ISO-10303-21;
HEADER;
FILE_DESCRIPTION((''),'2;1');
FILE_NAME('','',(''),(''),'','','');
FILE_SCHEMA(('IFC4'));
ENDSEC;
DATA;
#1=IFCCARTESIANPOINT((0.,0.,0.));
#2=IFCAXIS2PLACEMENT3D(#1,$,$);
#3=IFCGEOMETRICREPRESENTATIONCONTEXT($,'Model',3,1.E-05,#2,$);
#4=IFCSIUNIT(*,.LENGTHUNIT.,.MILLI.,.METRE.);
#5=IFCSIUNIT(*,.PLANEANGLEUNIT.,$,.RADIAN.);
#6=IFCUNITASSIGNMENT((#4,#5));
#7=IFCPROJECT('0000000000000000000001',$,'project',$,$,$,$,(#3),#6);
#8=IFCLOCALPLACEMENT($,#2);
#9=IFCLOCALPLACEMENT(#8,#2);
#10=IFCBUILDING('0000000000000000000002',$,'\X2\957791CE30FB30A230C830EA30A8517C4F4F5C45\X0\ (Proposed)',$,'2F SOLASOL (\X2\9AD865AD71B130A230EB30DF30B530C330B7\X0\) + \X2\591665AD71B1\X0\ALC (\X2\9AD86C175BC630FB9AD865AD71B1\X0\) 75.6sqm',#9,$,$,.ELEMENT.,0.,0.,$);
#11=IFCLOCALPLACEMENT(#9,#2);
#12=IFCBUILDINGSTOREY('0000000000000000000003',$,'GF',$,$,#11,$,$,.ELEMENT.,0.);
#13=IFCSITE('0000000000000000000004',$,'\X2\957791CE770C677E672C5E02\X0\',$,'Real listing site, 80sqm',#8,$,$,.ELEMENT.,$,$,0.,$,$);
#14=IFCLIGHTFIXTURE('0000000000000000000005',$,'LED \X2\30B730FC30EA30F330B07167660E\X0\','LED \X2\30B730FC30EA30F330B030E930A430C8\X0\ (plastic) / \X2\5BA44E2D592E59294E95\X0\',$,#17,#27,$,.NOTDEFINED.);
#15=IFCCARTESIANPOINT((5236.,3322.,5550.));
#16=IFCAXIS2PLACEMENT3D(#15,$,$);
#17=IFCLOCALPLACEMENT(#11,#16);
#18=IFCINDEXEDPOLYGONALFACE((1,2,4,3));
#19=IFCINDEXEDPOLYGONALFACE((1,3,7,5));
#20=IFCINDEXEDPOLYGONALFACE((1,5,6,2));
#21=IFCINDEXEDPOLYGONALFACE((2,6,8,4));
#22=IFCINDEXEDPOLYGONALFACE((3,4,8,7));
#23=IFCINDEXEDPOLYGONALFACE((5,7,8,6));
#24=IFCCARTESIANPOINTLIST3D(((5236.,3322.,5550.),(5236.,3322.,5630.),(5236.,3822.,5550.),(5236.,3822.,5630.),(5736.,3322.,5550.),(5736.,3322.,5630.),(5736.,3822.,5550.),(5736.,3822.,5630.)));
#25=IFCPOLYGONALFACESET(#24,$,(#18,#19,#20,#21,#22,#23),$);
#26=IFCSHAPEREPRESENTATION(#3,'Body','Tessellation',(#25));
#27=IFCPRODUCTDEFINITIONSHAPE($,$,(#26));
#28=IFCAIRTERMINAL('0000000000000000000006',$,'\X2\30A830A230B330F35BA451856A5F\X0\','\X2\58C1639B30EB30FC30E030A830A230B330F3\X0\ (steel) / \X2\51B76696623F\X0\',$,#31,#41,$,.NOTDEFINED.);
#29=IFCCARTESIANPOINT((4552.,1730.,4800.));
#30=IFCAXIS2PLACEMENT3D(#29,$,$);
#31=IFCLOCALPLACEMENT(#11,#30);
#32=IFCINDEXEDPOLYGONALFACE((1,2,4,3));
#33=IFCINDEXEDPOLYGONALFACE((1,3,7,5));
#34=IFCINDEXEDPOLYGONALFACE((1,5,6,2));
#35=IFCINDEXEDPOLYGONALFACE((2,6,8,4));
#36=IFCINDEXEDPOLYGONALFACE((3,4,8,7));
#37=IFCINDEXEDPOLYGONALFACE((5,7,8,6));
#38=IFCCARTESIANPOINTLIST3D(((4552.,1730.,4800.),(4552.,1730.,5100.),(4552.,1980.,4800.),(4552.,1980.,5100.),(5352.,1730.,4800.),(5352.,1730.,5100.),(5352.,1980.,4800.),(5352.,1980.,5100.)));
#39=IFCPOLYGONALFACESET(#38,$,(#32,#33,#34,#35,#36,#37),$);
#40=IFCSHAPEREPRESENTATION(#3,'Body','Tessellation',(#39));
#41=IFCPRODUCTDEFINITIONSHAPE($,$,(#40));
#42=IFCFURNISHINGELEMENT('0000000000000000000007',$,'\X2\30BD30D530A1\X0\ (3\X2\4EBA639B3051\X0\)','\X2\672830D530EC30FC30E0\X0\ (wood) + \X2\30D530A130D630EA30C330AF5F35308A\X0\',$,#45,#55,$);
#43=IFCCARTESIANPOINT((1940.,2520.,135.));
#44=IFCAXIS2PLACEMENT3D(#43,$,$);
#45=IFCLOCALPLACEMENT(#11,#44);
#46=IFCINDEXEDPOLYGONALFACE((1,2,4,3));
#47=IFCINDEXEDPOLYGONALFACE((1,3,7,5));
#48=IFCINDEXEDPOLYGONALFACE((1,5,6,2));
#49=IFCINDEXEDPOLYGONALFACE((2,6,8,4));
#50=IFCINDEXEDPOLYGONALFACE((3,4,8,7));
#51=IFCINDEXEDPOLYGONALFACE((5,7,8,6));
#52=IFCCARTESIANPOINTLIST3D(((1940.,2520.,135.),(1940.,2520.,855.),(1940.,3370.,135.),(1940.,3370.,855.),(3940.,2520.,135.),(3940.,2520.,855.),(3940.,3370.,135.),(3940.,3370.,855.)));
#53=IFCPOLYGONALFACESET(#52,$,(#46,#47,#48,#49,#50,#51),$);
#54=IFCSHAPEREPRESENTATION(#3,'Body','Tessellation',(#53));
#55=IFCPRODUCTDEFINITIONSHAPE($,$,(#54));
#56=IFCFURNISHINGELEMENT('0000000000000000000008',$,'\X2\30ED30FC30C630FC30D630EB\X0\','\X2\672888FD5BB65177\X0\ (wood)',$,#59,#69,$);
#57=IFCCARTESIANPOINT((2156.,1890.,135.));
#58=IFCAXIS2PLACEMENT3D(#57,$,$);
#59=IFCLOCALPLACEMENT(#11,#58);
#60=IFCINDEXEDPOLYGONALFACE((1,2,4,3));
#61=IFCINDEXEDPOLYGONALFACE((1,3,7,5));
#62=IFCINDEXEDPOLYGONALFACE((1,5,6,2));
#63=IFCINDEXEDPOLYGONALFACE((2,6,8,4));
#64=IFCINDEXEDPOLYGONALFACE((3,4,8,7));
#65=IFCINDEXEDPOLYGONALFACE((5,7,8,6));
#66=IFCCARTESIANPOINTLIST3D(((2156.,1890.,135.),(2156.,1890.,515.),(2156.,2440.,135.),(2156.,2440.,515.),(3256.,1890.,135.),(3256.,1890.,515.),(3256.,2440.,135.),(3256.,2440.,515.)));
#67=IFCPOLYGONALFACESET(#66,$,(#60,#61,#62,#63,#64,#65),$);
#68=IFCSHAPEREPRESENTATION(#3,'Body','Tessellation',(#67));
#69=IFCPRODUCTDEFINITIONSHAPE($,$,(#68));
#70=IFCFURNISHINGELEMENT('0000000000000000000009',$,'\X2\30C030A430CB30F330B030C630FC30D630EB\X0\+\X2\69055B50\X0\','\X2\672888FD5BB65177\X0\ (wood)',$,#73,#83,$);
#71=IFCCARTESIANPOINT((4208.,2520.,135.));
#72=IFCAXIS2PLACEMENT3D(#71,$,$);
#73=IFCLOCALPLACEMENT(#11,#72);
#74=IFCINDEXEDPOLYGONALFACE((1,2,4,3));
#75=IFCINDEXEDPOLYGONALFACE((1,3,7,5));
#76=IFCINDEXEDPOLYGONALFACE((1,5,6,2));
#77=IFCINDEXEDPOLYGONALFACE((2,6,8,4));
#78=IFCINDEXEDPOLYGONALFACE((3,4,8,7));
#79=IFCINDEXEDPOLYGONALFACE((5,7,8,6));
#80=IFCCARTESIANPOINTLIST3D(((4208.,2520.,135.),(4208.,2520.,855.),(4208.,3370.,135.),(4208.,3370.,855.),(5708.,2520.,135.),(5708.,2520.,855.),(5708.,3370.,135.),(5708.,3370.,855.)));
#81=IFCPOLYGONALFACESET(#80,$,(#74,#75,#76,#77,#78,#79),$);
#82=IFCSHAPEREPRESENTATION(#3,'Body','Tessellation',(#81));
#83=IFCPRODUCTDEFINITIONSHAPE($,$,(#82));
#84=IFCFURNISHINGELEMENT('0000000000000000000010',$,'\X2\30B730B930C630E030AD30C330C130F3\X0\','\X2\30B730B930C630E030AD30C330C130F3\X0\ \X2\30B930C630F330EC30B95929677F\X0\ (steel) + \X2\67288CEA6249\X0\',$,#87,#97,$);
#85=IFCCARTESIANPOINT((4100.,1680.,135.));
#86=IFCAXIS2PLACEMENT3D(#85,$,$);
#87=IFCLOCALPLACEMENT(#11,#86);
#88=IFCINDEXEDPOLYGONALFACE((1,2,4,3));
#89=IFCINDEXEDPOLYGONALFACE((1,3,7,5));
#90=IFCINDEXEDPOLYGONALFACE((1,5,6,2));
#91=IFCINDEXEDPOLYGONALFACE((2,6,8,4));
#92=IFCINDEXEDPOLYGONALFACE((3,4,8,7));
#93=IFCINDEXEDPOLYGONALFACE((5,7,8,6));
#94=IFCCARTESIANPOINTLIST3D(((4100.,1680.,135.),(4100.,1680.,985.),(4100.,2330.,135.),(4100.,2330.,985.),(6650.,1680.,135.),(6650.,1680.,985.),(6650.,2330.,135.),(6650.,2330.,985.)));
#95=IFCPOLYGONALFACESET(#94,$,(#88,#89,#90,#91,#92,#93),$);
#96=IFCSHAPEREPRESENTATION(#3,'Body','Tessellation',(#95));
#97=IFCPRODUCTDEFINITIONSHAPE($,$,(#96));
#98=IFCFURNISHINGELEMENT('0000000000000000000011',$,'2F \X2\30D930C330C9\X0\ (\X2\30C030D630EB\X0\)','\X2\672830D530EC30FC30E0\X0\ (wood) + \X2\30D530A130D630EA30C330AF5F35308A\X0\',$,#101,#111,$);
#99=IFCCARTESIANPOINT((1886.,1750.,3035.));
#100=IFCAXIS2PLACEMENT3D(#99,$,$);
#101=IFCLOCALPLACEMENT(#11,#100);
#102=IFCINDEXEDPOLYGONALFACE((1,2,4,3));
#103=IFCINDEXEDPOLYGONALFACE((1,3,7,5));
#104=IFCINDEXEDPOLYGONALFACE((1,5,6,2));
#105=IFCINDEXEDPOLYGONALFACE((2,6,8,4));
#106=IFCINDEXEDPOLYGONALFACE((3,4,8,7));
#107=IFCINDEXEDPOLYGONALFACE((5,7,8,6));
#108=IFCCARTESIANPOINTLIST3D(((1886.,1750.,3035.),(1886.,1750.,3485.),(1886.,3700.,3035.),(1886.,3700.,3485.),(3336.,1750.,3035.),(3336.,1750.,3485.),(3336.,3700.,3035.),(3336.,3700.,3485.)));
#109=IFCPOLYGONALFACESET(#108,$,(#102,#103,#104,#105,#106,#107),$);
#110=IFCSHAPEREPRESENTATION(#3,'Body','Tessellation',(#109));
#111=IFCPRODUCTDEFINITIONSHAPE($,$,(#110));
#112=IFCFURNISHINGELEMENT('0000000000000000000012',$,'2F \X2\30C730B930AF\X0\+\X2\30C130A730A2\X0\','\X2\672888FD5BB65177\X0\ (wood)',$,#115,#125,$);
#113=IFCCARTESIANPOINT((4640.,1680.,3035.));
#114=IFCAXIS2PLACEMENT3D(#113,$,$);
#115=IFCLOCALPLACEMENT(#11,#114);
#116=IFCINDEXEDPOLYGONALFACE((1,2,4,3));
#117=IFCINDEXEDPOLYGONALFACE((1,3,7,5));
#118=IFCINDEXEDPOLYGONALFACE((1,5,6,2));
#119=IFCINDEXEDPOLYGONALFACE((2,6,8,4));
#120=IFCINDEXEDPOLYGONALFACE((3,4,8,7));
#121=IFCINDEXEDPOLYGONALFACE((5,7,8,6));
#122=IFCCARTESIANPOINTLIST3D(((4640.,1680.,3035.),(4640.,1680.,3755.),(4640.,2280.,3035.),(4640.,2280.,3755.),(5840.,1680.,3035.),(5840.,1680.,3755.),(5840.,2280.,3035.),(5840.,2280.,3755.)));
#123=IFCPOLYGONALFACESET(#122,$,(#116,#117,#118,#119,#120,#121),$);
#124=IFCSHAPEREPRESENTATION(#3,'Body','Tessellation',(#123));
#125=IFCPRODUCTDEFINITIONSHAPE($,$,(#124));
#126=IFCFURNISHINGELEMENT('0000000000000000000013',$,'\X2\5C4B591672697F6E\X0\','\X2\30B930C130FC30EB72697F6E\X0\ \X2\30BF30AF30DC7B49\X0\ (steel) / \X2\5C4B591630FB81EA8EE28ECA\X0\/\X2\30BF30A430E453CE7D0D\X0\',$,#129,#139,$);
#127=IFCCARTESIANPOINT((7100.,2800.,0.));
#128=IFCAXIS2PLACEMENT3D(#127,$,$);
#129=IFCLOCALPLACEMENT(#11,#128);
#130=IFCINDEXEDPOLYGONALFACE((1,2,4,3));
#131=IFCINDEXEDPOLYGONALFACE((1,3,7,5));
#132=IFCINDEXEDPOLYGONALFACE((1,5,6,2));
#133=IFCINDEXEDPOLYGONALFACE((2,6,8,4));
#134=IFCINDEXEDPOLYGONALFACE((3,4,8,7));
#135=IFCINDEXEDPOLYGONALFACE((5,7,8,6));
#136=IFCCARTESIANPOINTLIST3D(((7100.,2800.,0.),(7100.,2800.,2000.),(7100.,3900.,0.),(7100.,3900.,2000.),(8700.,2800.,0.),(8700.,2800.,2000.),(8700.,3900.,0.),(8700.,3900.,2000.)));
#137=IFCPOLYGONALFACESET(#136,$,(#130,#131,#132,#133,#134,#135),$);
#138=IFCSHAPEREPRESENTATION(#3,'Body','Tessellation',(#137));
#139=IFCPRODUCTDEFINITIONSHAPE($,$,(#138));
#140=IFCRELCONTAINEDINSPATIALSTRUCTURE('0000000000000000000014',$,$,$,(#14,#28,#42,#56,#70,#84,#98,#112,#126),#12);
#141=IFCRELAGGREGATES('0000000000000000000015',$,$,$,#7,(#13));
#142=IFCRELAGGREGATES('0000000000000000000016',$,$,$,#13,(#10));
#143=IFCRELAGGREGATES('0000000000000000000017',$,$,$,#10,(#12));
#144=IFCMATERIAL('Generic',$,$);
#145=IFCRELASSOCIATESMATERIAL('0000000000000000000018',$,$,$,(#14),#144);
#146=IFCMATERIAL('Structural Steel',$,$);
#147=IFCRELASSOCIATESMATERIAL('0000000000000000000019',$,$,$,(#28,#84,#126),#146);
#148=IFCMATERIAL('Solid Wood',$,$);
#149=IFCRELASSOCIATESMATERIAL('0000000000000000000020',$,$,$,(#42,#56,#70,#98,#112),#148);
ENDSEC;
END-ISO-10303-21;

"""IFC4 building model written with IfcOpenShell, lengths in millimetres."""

from ifc_helpers import new_model, si_unit, frame, frame_2d, origin, place, context, project, spatial, rectangle, extrude, material, element, save


model = new_model("IFC4")

# Units and contexts
model_context = context("Model", 3, precision=1e-05, world=origin())
ifc_project = project(units=[si_unit("LENGTHUNIT", "METRE", prefix="MILLI"), si_unit("PLANEANGLEUNIT", "RADIAN")], contexts=[model_context])

# Site, building, storey
site_placement = place(None, origin())
site = spatial("IfcSite", under=ifc_project, at=site_placement, Name="長野県松本市", ObjectType="Real listing site, 80sqm", CompositionType="ELEMENT", RefElevation=0.0)
building_placement = place(site_placement, origin())
building = spatial("IfcBuilding", under=site, at=building_placement, Name="長野・アトリエ兼住居 (Proposed)", ObjectType="2F SOLASOL (高断熱アルミサッシ) + 外断熱ALC (高気密・高断熱) 75.6sqm", CompositionType="ELEMENT", ElevationOfRefHeight=0.0, ElevationOfTerrain=0.0)
storey_placement = place(building_placement, origin())
storey = spatial("IfcBuildingStorey", under=building, at=storey_placement, Name="GF", CompositionType="ELEMENT", Elevation=0.0)

# Shared definitions
ifc_material_1 = material(Name="Solid Wood")

# Shared definitions
ifc_material_2 = material(Name="Generic")

# Shared definitions
ifc_material_3 = material(Name="Structural Steel")

# Light fixture
light_fixture_placement = place(storey_placement, frame((5236.0, 3322.0, 5550.0)))
element("IfcLightFixture", 1, at=light_fixture_placement, inside=storey, material=ifc_material_2, Name="LED シーリング照明", Description="LED シーリングライト (plastic) / 室中央天井", PredefinedType="NOTDEFINED", context=model_context, shape_type="SweptSolid", body=[
    extrude(rectangle(XDim=500.0, YDim=500.0, at=frame_2d((250.0, 250.0))), frame((5236.0, 3322.0, 5550.0)), (0.0, 0.0, 1.0), 80.0),
])

# Air terminal
air_terminal_1_placement = place(storey_placement, frame((4552.0, 1730.0, 4800.0)))
element("IfcAirTerminal", 2, at=air_terminal_1_placement, inside=storey, material=ifc_material_3, Name="エアコン室内機", Description="壁掛ルームエアコン (steel) / 冷暖房", PredefinedType="NOTDEFINED", context=model_context, shape_type="SweptSolid", body=[
    extrude(rectangle(XDim=800.0, YDim=250.0, at=frame_2d((400.0, 125.0))), frame((4552.0, 1730.0, 4800.0)), (0.0, 0.0, 1.0), 300.0),
])

# Furnishing elements
furnishing_1_placement = place(storey_placement, frame((1940.0, 2520.0, 135.0)))
element("IfcFurnishingElement", 3, at=furnishing_1_placement, inside=storey, material=ifc_material_1, Name="ソファ (3人掛け)", Description="木フレーム (wood) + ファブリック張り", context=model_context, shape_type="SweptSolid", body=[
    extrude(rectangle(XDim=2000.0, YDim=850.0, at=frame_2d((1000.0, 425.0))), frame((1940.0, 2520.0, 135.0)), (0.0, 0.0, 1.0), 720.0),
])
furnishing_2_placement = place(storey_placement, frame((2156.0, 1890.0, 135.0)))
element("IfcFurnishingElement", 4, at=furnishing_2_placement, inside=storey, material=ifc_material_1, Name="ローテーブル", Description="木製家具 (wood)", context=model_context, shape_type="SweptSolid", body=[
    extrude(rectangle(XDim=1100.0, YDim=550.0, at=frame_2d((550.0, 275.0))), frame((2156.0, 1890.0, 135.0)), (0.0, 0.0, 1.0), 380.0),
])
furnishing_3_placement = place(storey_placement, frame((4208.0, 2520.0, 135.0)))
element("IfcFurnishingElement", 5, at=furnishing_3_placement, inside=storey, material=ifc_material_1, Name="ダイニングテーブル+椅子", Description="木製家具 (wood)", context=model_context, shape_type="SweptSolid", body=[
    extrude(rectangle(XDim=1500.0, YDim=850.0, at=frame_2d((750.0, 425.0))), frame((4208.0, 2520.0, 135.0)), (0.0, 0.0, 1.0), 720.0),
])
furnishing_4_placement = place(storey_placement, frame((4100.0, 1680.0, 135.0)))
element("IfcFurnishingElement", 6, at=furnishing_4_placement, inside=storey, material=ifc_material_3, Name="システムキッチン", Description="システムキッチン ステンレス天板 (steel) + 木質扉", context=model_context, shape_type="SweptSolid", body=[
    extrude(rectangle(XDim=2550.0, YDim=650.0, at=frame_2d((1275.0, 325.0))), frame((4100.0, 1680.0, 135.0)), (0.0, 0.0, 1.0), 850.0),
])
furnishing_5_placement = place(storey_placement, frame((1886.0, 1750.0, 3035.0)))
element("IfcFurnishingElement", 7, at=furnishing_5_placement, inside=storey, material=ifc_material_1, Name="2F ベッド (ダブル)", Description="木フレーム (wood) + ファブリック張り", context=model_context, shape_type="SweptSolid", body=[
    extrude(rectangle(XDim=1450.0, YDim=1950.0, at=frame_2d((725.0, 975.0))), frame((1886.0, 1750.0, 3035.0)), (0.0, 0.0, 1.0), 450.0),
])
furnishing_6_placement = place(storey_placement, frame((4640.0, 1680.0, 3035.0)))
element("IfcFurnishingElement", 8, at=furnishing_6_placement, inside=storey, material=ifc_material_1, Name="2F デスク+チェア", Description="木製家具 (wood)", context=model_context, shape_type="SweptSolid", body=[
    extrude(rectangle(XDim=1200.0, YDim=600.0, at=frame_2d((600.0, 300.0))), frame((4640.0, 1680.0, 3035.0)), (0.0, 0.0, 1.0), 720.0),
])
furnishing_7_placement = place(storey_placement, frame((7100.0, 2800.0, 0.0)))
element("IfcFurnishingElement", 9, at=furnishing_7_placement, inside=storey, material=ifc_material_3, Name="屋外物置", Description="スチール物置 タクボ等 (steel) / 屋外・自転車/タイヤ収納", context=model_context, shape_type="SweptSolid", body=[
    extrude(rectangle(XDim=1600.0, YDim=1100.0, at=frame_2d((800.0, 550.0))), frame((7100.0, 2800.0, 0.0)), (0.0, 0.0, 1.0), 2000.0),
])

save(model, "model.ifc")
